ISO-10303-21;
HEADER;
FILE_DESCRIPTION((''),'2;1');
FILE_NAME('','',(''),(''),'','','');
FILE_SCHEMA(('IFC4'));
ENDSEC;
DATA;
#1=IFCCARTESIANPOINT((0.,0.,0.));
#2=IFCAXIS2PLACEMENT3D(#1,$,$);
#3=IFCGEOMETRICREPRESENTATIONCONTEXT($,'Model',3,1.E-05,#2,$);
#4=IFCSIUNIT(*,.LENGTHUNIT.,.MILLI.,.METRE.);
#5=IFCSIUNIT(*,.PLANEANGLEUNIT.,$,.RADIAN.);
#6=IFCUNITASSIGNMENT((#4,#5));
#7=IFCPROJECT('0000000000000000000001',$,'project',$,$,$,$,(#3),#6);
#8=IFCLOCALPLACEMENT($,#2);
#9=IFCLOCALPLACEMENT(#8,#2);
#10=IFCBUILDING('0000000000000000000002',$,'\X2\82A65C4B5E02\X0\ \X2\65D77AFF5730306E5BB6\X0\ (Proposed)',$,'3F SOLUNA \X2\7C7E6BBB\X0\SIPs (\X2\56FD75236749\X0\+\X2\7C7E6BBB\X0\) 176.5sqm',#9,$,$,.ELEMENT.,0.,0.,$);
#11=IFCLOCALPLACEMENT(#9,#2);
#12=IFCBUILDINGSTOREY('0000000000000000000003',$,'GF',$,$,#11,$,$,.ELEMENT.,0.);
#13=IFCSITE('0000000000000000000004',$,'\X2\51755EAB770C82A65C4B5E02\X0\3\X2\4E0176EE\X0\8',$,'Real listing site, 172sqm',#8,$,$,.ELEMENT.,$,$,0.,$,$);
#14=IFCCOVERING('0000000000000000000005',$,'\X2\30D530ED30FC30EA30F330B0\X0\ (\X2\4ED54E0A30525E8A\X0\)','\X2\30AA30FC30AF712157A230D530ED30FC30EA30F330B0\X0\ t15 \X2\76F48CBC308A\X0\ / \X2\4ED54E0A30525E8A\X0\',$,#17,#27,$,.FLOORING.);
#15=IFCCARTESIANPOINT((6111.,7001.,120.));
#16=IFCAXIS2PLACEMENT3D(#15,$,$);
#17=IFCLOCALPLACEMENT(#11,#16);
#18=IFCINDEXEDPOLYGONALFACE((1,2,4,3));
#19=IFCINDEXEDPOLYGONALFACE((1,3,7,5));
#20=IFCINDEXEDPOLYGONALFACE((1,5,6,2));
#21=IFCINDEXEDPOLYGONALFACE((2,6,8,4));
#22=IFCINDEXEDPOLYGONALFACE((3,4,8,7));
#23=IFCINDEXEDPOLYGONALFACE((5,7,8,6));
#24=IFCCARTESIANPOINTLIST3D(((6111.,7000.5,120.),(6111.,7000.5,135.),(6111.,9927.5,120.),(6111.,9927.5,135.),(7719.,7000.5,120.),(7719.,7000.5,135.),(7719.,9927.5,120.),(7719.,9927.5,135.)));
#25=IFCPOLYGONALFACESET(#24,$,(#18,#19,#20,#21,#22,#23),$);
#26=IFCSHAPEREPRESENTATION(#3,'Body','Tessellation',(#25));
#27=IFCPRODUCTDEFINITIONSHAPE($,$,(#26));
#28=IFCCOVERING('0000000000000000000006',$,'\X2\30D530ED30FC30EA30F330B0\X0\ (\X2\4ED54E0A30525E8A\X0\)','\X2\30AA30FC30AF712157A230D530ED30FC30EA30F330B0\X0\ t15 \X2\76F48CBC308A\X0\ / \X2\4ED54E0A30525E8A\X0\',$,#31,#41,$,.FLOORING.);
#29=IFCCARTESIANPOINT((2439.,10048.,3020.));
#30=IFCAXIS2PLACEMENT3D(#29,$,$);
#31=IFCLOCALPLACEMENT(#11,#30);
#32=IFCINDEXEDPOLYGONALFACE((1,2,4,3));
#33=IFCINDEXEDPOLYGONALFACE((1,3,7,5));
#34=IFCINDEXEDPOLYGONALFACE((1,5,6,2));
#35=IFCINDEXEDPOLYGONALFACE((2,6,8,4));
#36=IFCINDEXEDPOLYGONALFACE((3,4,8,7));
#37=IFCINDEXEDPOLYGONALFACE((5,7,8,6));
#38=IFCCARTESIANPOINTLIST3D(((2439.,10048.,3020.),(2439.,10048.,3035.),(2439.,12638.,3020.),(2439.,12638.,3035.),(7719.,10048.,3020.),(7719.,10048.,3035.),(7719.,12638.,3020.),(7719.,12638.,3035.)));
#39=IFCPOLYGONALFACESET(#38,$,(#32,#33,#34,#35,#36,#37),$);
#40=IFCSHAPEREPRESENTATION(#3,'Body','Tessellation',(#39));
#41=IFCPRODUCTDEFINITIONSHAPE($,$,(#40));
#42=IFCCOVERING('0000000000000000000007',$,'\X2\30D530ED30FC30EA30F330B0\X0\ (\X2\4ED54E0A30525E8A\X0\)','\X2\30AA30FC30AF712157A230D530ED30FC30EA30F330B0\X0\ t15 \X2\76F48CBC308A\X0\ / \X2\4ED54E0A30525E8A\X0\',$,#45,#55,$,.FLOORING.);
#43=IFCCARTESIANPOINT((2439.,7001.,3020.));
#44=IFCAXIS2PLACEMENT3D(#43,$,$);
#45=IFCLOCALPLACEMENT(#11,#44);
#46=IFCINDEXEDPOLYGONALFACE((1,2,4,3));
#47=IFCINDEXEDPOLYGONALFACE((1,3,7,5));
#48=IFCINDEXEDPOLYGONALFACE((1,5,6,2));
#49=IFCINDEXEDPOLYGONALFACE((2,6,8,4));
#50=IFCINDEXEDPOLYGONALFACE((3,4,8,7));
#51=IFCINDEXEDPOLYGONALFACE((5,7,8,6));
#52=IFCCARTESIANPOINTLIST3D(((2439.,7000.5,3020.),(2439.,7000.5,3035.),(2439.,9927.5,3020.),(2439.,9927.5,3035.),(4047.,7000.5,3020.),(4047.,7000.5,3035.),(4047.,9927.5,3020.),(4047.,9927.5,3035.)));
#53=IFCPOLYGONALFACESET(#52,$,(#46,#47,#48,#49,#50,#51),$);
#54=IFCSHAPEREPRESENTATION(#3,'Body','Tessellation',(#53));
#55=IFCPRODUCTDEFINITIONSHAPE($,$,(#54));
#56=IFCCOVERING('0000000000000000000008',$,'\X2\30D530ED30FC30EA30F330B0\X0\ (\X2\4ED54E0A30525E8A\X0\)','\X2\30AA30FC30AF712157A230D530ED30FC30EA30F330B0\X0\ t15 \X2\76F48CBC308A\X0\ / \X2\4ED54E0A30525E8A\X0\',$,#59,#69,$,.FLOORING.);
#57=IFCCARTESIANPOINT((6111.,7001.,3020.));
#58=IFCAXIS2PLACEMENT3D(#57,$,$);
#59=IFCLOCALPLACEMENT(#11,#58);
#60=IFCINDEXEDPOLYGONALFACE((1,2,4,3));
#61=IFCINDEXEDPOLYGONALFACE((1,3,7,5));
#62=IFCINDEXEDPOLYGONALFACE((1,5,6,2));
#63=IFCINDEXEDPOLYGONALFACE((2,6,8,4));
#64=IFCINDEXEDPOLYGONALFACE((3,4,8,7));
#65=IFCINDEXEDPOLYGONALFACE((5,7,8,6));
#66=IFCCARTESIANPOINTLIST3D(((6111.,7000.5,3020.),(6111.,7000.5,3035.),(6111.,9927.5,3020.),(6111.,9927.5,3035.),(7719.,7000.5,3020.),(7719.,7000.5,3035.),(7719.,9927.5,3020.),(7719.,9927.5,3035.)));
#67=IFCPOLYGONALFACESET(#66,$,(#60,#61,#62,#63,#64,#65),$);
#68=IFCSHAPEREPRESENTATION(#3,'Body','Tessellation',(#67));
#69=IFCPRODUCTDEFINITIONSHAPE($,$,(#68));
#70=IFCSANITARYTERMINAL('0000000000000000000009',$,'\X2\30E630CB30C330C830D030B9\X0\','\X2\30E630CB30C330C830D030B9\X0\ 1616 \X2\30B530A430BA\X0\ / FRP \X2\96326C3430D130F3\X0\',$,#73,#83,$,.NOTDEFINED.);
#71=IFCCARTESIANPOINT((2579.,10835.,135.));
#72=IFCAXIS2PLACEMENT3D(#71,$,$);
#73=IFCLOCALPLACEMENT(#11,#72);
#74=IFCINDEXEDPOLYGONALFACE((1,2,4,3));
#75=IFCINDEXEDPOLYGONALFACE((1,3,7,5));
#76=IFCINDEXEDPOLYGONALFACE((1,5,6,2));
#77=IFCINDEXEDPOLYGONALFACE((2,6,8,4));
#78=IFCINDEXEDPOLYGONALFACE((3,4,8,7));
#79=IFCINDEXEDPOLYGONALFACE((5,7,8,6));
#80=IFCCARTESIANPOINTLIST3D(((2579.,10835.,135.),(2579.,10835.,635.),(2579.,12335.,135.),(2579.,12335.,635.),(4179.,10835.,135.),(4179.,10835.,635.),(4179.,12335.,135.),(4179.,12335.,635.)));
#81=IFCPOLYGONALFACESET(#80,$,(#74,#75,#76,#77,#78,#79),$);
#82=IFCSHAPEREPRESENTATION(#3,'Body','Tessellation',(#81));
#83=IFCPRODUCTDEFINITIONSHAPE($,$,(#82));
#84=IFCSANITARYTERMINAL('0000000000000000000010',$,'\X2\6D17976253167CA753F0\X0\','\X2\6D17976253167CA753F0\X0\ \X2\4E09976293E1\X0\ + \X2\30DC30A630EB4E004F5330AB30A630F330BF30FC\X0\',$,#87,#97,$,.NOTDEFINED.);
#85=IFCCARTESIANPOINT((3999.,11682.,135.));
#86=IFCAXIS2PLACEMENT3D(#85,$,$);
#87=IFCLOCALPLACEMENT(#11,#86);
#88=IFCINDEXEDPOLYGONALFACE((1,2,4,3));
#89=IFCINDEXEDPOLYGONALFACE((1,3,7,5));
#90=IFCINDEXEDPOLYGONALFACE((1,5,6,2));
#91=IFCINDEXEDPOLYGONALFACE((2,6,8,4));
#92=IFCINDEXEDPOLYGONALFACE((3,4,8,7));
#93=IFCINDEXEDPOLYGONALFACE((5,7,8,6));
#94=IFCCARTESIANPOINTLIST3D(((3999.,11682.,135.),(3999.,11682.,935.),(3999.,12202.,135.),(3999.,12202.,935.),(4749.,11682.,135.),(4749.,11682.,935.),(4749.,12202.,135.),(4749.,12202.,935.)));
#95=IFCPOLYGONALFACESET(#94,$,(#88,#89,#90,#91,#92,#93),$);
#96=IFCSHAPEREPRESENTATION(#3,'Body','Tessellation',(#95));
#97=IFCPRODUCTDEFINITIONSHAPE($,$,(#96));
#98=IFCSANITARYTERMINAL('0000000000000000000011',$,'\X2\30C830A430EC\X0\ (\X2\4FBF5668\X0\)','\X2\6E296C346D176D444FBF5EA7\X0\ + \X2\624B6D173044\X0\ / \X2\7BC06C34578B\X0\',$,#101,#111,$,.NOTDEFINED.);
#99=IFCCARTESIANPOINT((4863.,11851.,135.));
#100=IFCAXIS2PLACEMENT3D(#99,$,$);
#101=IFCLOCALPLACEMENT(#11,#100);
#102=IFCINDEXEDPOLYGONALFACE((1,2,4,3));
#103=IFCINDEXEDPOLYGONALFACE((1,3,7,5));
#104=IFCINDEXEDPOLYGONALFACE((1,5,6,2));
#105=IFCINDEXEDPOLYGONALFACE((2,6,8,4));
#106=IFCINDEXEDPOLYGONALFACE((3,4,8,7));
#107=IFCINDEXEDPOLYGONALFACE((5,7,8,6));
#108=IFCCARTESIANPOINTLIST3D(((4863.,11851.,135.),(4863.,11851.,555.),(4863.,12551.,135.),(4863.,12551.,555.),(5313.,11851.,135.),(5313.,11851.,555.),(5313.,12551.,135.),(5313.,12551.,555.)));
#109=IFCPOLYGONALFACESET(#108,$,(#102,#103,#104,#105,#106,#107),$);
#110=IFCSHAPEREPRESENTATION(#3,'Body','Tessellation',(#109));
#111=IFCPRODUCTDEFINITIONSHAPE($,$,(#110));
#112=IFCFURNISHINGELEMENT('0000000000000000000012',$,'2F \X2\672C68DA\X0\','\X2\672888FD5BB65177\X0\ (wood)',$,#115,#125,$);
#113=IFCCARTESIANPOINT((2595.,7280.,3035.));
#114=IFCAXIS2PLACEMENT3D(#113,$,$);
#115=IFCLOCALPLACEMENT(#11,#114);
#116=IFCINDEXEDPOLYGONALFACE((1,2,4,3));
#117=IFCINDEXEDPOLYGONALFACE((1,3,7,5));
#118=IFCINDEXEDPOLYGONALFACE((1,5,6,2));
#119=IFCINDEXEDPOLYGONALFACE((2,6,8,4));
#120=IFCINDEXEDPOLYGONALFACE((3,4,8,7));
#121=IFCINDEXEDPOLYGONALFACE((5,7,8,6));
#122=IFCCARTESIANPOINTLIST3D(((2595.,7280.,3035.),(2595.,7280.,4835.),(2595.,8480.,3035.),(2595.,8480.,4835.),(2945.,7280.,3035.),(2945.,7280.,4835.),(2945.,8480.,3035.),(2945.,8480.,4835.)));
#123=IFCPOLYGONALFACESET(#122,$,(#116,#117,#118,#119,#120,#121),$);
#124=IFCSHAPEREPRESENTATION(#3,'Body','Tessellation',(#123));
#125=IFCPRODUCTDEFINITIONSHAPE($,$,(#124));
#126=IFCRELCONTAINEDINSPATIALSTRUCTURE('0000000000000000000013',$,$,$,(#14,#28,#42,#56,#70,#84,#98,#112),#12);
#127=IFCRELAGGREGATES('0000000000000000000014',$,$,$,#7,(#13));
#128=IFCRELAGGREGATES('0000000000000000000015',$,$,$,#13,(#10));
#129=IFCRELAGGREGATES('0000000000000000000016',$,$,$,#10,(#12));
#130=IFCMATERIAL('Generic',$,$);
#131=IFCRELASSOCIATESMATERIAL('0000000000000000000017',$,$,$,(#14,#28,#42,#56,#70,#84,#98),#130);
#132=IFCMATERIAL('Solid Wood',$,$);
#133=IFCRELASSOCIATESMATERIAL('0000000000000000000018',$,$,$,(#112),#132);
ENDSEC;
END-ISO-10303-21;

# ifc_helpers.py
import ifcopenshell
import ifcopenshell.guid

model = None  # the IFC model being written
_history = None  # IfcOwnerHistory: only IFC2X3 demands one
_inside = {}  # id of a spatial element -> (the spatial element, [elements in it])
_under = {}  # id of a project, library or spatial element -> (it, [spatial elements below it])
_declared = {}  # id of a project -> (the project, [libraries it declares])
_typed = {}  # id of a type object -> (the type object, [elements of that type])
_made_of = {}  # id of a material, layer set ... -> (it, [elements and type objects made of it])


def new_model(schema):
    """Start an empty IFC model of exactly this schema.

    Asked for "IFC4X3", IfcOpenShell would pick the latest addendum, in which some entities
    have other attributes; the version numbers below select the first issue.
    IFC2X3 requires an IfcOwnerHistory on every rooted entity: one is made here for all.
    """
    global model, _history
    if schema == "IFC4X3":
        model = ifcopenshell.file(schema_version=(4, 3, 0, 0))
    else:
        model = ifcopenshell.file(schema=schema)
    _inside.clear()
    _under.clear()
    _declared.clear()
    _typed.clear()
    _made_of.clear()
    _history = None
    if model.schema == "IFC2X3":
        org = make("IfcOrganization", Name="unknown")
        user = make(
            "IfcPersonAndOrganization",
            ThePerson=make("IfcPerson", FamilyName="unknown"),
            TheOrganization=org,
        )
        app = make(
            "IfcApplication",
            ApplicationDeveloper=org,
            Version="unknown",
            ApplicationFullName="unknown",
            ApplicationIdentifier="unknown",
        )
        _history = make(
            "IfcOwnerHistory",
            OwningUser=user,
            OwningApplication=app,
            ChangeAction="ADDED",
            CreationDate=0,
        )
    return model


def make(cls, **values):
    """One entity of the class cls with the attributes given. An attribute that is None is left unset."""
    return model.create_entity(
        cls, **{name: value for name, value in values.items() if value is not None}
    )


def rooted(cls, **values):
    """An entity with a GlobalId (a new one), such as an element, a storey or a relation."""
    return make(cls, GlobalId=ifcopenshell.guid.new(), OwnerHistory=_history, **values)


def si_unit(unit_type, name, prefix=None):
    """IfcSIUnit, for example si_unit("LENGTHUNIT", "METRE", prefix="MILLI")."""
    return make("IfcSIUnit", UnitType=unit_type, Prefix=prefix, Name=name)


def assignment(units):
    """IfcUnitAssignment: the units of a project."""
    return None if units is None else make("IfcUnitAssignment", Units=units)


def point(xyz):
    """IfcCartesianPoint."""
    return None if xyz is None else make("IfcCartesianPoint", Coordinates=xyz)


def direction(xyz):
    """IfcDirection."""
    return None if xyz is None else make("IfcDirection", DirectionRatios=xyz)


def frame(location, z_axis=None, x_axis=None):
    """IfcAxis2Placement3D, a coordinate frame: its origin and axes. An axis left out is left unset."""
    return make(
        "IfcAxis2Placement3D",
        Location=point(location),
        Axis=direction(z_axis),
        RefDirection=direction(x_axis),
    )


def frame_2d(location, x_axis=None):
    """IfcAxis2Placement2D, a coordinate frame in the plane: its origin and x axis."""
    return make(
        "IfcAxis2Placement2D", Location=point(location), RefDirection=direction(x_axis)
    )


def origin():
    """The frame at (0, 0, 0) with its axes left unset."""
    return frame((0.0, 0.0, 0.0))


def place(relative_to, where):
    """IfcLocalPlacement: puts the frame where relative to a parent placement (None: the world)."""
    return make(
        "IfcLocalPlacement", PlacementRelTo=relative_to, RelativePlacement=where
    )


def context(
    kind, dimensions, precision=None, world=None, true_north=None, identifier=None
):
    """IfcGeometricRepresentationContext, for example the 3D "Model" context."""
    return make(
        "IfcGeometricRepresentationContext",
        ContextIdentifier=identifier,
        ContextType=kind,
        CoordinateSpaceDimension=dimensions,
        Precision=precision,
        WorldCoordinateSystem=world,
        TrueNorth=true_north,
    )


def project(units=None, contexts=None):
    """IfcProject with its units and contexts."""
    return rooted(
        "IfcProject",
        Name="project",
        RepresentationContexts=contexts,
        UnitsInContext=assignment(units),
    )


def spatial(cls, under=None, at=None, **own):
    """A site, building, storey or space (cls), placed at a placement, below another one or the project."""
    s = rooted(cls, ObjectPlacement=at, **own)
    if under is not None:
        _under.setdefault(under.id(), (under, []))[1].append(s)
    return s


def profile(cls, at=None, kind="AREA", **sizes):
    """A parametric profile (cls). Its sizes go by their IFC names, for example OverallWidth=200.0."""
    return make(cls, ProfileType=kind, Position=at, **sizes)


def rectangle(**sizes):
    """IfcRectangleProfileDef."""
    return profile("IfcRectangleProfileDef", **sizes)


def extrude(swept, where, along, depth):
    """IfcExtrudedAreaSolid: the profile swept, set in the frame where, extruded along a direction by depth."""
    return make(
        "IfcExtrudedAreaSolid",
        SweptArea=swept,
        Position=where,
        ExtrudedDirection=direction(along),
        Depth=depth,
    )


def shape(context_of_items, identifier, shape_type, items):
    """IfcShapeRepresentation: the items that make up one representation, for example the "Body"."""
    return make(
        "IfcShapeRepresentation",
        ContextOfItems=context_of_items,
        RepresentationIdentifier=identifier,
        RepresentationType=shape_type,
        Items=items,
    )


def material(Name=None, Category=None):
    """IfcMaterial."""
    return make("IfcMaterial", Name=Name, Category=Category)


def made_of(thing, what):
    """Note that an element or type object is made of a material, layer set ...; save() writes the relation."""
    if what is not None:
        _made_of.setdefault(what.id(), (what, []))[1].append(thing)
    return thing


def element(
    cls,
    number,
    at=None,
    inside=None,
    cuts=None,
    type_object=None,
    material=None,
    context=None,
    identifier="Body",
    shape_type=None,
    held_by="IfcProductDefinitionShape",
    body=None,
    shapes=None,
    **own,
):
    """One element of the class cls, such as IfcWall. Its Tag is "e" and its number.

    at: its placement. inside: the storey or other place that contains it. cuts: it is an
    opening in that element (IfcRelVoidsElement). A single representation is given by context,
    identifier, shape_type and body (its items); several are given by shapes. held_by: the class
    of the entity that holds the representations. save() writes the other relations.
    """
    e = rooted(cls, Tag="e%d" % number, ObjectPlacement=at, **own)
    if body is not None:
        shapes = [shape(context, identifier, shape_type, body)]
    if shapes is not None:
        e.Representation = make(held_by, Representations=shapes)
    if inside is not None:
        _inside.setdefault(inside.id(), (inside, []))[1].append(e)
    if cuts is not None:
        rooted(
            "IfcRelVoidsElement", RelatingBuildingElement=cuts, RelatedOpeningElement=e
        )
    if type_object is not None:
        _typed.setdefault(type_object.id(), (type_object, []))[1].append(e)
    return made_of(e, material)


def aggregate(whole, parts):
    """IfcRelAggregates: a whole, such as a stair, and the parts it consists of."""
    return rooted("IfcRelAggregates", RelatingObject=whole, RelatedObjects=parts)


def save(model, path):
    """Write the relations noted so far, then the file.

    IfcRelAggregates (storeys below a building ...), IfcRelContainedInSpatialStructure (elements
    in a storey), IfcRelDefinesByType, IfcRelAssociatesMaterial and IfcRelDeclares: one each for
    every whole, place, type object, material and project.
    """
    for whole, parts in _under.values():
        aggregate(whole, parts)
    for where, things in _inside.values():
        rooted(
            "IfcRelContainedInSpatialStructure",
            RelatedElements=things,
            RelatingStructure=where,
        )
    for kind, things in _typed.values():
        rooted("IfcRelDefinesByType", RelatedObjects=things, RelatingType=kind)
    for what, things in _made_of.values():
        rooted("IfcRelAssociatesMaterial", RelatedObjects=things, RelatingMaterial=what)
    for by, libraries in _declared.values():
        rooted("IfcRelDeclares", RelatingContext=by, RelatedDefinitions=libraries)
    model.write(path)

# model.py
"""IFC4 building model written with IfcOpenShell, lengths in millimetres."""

from ifc_helpers import new_model, si_unit, frame, frame_2d, origin, place, context, project, spatial, rectangle, extrude, material, element, save


model = new_model("IFC4")

# Units and contexts
model_context = context("Model", 3, precision=1e-05, world=origin())
ifc_project = project(units=[si_unit("LENGTHUNIT", "METRE", prefix="MILLI"), si_unit("PLANEANGLEUNIT", "RADIAN")], contexts=[model_context])

# Site, building, storey
site_placement = place(None, origin())
site = spatial("IfcSite", under=ifc_project, at=site_placement, Name="兵庫県芦屋市3丁目8", ObjectType="Real listing site, 172sqm", CompositionType="ELEMENT", RefElevation=0.0)
building_placement = place(site_placement, origin())
building = spatial("IfcBuilding", under=site, at=building_placement, Name="芦屋市 旗竿地の家 (Proposed)", ObjectType="3F SOLUNA 籾殻SIPs (国産杉+籾殻) 176.5sqm", CompositionType="ELEMENT", ElevationOfRefHeight=0.0, ElevationOfTerrain=0.0)
storey_placement = place(building_placement, origin())
storey = spatial("IfcBuildingStorey", under=building, at=storey_placement, Name="GF", CompositionType="ELEMENT", Elevation=0.0)

# Shared definitions
ifc_material_1 = material(Name="Solid Wood")

# Coverings
ifc_material_2 = material(Name="Generic")
covering_1_placement = place(storey_placement, frame((6111.0, 7001.0, 120.0)))
element("IfcCovering", 1, at=covering_1_placement, inside=storey, material=ifc_material_2, Name="フローリング (仕上げ床)", Description="オーク無垢フローリング t15 直貼り / 仕上げ床", PredefinedType="FLOORING", context=model_context, shape_type="SweptSolid", body=[
    extrude(rectangle(XDim=1608.0, YDim=2927.0, at=frame_2d((804.0, 1463.0))), frame((6111.0, 7001.0, 120.0)), (0.0, 0.0, 1.0), 15.0),
])
covering_2_placement = place(storey_placement, frame((2439.0, 10048.0, 3020.0)))
element("IfcCovering", 2, at=covering_2_placement, inside=storey, material=ifc_material_2, Name="フローリング (仕上げ床)", Description="オーク無垢フローリング t15 直貼り / 仕上げ床", PredefinedType="FLOORING", context=model_context, shape_type="SweptSolid", body=[
    extrude(rectangle(XDim=5280.0, YDim=2590.0, at=frame_2d((2640.0, 1295.0))), frame((2439.0, 10048.0, 3020.0)), (0.0, 0.0, 1.0), 15.0),
])
covering_3_placement = place(storey_placement, frame((2439.0, 7001.0, 3020.0)))
element("IfcCovering", 3, at=covering_3_placement, inside=storey, material=ifc_material_2, Name="フローリング (仕上げ床)", Description="オーク無垢フローリング t15 直貼り / 仕上げ床", PredefinedType="FLOORING", context=model_context, shape_type="SweptSolid", body=[
    extrude(rectangle(XDim=1608.0, YDim=2927.0, at=frame_2d((804.0, 1463.0))), frame((2439.0, 7001.0, 3020.0)), (0.0, 0.0, 1.0), 15.0),
])
covering_4_placement = place(storey_placement, frame((6111.0, 7001.0, 3020.0)))
element("IfcCovering", 4, at=covering_4_placement, inside=storey, material=ifc_material_2, Name="フローリング (仕上げ床)", Description="オーク無垢フローリング t15 直貼り / 仕上げ床", PredefinedType="FLOORING", context=model_context, shape_type="SweptSolid", body=[
    extrude(rectangle(XDim=1608.0, YDim=2927.0, at=frame_2d((804.0, 1463.0))), frame((6111.0, 7001.0, 3020.0)), (0.0, 0.0, 1.0), 15.0),
])

# Sanitary terminals
sanitary_terminal_1_placement = place(storey_placement, frame((2579.0, 10835.0, 135.0)))
element("IfcSanitaryTerminal", 5, at=sanitary_terminal_1_placement, inside=storey, material=ifc_material_2, Name="ユニットバス", Description="ユニットバス 1616 サイズ / FRP 防水パン", PredefinedType="NOTDEFINED", context=model_context, shape_type="SweptSolid", body=[
    extrude(rectangle(XDim=1600.0, YDim=1500.0, at=frame_2d((800.0, 750.0))), frame((2579.0, 10835.0, 135.0)), (0.0, 0.0, 1.0), 500.0),
])
sanitary_terminal_2_placement = place(storey_placement, frame((3999.0, 11682.0, 135.0)))
element("IfcSanitaryTerminal", 6, at=sanitary_terminal_2_placement, inside=storey, material=ifc_material_2, Name="洗面化粧台", Description="洗面化粧台 三面鏡 + ボウル一体カウンター", PredefinedType="NOTDEFINED", context=model_context, shape_type="SweptSolid", body=[
    extrude(rectangle(XDim=750.0, YDim=520.0, at=frame_2d((375.0, 260.0))), frame((3999.0, 11682.0, 135.0)), (0.0, 0.0, 1.0), 800.0),
])
sanitary_terminal_3_placement = place(storey_placement, frame((4863.0, 11851.0, 135.0)))
element("IfcSanitaryTerminal", 7, at=sanitary_terminal_3_placement, inside=storey, material=ifc_material_2, Name="トイレ (便器)", Description="温水洗浄便座 + 手洗い / 節水型", PredefinedType="NOTDEFINED", context=model_context, shape_type="SweptSolid", body=[
    extrude(rectangle(XDim=450.0, YDim=700.0, at=frame_2d((225.0, 350.0))), frame((4863.0, 11851.0, 135.0)), (0.0, 0.0, 1.0), 420.0),
])

# Furnishing element
furnishing_placement = place(storey_placement, frame((2595.0, 7280.0, 3035.0)))
element("IfcFurnishingElement", 8, at=furnishing_placement, inside=storey, material=ifc_material_1, Name="2F 本棚", Description="木製家具 (wood)", context=model_context, shape_type="SweptSolid", body=[
    extrude(rectangle(XDim=350.0, YDim=1200.0, at=frame_2d((175.0, 600.0))), frame((2595.0, 7280.0, 3035.0)), (0.0, 0.0, 1.0), 1800.0),
])

save(model, "model.ifc")
